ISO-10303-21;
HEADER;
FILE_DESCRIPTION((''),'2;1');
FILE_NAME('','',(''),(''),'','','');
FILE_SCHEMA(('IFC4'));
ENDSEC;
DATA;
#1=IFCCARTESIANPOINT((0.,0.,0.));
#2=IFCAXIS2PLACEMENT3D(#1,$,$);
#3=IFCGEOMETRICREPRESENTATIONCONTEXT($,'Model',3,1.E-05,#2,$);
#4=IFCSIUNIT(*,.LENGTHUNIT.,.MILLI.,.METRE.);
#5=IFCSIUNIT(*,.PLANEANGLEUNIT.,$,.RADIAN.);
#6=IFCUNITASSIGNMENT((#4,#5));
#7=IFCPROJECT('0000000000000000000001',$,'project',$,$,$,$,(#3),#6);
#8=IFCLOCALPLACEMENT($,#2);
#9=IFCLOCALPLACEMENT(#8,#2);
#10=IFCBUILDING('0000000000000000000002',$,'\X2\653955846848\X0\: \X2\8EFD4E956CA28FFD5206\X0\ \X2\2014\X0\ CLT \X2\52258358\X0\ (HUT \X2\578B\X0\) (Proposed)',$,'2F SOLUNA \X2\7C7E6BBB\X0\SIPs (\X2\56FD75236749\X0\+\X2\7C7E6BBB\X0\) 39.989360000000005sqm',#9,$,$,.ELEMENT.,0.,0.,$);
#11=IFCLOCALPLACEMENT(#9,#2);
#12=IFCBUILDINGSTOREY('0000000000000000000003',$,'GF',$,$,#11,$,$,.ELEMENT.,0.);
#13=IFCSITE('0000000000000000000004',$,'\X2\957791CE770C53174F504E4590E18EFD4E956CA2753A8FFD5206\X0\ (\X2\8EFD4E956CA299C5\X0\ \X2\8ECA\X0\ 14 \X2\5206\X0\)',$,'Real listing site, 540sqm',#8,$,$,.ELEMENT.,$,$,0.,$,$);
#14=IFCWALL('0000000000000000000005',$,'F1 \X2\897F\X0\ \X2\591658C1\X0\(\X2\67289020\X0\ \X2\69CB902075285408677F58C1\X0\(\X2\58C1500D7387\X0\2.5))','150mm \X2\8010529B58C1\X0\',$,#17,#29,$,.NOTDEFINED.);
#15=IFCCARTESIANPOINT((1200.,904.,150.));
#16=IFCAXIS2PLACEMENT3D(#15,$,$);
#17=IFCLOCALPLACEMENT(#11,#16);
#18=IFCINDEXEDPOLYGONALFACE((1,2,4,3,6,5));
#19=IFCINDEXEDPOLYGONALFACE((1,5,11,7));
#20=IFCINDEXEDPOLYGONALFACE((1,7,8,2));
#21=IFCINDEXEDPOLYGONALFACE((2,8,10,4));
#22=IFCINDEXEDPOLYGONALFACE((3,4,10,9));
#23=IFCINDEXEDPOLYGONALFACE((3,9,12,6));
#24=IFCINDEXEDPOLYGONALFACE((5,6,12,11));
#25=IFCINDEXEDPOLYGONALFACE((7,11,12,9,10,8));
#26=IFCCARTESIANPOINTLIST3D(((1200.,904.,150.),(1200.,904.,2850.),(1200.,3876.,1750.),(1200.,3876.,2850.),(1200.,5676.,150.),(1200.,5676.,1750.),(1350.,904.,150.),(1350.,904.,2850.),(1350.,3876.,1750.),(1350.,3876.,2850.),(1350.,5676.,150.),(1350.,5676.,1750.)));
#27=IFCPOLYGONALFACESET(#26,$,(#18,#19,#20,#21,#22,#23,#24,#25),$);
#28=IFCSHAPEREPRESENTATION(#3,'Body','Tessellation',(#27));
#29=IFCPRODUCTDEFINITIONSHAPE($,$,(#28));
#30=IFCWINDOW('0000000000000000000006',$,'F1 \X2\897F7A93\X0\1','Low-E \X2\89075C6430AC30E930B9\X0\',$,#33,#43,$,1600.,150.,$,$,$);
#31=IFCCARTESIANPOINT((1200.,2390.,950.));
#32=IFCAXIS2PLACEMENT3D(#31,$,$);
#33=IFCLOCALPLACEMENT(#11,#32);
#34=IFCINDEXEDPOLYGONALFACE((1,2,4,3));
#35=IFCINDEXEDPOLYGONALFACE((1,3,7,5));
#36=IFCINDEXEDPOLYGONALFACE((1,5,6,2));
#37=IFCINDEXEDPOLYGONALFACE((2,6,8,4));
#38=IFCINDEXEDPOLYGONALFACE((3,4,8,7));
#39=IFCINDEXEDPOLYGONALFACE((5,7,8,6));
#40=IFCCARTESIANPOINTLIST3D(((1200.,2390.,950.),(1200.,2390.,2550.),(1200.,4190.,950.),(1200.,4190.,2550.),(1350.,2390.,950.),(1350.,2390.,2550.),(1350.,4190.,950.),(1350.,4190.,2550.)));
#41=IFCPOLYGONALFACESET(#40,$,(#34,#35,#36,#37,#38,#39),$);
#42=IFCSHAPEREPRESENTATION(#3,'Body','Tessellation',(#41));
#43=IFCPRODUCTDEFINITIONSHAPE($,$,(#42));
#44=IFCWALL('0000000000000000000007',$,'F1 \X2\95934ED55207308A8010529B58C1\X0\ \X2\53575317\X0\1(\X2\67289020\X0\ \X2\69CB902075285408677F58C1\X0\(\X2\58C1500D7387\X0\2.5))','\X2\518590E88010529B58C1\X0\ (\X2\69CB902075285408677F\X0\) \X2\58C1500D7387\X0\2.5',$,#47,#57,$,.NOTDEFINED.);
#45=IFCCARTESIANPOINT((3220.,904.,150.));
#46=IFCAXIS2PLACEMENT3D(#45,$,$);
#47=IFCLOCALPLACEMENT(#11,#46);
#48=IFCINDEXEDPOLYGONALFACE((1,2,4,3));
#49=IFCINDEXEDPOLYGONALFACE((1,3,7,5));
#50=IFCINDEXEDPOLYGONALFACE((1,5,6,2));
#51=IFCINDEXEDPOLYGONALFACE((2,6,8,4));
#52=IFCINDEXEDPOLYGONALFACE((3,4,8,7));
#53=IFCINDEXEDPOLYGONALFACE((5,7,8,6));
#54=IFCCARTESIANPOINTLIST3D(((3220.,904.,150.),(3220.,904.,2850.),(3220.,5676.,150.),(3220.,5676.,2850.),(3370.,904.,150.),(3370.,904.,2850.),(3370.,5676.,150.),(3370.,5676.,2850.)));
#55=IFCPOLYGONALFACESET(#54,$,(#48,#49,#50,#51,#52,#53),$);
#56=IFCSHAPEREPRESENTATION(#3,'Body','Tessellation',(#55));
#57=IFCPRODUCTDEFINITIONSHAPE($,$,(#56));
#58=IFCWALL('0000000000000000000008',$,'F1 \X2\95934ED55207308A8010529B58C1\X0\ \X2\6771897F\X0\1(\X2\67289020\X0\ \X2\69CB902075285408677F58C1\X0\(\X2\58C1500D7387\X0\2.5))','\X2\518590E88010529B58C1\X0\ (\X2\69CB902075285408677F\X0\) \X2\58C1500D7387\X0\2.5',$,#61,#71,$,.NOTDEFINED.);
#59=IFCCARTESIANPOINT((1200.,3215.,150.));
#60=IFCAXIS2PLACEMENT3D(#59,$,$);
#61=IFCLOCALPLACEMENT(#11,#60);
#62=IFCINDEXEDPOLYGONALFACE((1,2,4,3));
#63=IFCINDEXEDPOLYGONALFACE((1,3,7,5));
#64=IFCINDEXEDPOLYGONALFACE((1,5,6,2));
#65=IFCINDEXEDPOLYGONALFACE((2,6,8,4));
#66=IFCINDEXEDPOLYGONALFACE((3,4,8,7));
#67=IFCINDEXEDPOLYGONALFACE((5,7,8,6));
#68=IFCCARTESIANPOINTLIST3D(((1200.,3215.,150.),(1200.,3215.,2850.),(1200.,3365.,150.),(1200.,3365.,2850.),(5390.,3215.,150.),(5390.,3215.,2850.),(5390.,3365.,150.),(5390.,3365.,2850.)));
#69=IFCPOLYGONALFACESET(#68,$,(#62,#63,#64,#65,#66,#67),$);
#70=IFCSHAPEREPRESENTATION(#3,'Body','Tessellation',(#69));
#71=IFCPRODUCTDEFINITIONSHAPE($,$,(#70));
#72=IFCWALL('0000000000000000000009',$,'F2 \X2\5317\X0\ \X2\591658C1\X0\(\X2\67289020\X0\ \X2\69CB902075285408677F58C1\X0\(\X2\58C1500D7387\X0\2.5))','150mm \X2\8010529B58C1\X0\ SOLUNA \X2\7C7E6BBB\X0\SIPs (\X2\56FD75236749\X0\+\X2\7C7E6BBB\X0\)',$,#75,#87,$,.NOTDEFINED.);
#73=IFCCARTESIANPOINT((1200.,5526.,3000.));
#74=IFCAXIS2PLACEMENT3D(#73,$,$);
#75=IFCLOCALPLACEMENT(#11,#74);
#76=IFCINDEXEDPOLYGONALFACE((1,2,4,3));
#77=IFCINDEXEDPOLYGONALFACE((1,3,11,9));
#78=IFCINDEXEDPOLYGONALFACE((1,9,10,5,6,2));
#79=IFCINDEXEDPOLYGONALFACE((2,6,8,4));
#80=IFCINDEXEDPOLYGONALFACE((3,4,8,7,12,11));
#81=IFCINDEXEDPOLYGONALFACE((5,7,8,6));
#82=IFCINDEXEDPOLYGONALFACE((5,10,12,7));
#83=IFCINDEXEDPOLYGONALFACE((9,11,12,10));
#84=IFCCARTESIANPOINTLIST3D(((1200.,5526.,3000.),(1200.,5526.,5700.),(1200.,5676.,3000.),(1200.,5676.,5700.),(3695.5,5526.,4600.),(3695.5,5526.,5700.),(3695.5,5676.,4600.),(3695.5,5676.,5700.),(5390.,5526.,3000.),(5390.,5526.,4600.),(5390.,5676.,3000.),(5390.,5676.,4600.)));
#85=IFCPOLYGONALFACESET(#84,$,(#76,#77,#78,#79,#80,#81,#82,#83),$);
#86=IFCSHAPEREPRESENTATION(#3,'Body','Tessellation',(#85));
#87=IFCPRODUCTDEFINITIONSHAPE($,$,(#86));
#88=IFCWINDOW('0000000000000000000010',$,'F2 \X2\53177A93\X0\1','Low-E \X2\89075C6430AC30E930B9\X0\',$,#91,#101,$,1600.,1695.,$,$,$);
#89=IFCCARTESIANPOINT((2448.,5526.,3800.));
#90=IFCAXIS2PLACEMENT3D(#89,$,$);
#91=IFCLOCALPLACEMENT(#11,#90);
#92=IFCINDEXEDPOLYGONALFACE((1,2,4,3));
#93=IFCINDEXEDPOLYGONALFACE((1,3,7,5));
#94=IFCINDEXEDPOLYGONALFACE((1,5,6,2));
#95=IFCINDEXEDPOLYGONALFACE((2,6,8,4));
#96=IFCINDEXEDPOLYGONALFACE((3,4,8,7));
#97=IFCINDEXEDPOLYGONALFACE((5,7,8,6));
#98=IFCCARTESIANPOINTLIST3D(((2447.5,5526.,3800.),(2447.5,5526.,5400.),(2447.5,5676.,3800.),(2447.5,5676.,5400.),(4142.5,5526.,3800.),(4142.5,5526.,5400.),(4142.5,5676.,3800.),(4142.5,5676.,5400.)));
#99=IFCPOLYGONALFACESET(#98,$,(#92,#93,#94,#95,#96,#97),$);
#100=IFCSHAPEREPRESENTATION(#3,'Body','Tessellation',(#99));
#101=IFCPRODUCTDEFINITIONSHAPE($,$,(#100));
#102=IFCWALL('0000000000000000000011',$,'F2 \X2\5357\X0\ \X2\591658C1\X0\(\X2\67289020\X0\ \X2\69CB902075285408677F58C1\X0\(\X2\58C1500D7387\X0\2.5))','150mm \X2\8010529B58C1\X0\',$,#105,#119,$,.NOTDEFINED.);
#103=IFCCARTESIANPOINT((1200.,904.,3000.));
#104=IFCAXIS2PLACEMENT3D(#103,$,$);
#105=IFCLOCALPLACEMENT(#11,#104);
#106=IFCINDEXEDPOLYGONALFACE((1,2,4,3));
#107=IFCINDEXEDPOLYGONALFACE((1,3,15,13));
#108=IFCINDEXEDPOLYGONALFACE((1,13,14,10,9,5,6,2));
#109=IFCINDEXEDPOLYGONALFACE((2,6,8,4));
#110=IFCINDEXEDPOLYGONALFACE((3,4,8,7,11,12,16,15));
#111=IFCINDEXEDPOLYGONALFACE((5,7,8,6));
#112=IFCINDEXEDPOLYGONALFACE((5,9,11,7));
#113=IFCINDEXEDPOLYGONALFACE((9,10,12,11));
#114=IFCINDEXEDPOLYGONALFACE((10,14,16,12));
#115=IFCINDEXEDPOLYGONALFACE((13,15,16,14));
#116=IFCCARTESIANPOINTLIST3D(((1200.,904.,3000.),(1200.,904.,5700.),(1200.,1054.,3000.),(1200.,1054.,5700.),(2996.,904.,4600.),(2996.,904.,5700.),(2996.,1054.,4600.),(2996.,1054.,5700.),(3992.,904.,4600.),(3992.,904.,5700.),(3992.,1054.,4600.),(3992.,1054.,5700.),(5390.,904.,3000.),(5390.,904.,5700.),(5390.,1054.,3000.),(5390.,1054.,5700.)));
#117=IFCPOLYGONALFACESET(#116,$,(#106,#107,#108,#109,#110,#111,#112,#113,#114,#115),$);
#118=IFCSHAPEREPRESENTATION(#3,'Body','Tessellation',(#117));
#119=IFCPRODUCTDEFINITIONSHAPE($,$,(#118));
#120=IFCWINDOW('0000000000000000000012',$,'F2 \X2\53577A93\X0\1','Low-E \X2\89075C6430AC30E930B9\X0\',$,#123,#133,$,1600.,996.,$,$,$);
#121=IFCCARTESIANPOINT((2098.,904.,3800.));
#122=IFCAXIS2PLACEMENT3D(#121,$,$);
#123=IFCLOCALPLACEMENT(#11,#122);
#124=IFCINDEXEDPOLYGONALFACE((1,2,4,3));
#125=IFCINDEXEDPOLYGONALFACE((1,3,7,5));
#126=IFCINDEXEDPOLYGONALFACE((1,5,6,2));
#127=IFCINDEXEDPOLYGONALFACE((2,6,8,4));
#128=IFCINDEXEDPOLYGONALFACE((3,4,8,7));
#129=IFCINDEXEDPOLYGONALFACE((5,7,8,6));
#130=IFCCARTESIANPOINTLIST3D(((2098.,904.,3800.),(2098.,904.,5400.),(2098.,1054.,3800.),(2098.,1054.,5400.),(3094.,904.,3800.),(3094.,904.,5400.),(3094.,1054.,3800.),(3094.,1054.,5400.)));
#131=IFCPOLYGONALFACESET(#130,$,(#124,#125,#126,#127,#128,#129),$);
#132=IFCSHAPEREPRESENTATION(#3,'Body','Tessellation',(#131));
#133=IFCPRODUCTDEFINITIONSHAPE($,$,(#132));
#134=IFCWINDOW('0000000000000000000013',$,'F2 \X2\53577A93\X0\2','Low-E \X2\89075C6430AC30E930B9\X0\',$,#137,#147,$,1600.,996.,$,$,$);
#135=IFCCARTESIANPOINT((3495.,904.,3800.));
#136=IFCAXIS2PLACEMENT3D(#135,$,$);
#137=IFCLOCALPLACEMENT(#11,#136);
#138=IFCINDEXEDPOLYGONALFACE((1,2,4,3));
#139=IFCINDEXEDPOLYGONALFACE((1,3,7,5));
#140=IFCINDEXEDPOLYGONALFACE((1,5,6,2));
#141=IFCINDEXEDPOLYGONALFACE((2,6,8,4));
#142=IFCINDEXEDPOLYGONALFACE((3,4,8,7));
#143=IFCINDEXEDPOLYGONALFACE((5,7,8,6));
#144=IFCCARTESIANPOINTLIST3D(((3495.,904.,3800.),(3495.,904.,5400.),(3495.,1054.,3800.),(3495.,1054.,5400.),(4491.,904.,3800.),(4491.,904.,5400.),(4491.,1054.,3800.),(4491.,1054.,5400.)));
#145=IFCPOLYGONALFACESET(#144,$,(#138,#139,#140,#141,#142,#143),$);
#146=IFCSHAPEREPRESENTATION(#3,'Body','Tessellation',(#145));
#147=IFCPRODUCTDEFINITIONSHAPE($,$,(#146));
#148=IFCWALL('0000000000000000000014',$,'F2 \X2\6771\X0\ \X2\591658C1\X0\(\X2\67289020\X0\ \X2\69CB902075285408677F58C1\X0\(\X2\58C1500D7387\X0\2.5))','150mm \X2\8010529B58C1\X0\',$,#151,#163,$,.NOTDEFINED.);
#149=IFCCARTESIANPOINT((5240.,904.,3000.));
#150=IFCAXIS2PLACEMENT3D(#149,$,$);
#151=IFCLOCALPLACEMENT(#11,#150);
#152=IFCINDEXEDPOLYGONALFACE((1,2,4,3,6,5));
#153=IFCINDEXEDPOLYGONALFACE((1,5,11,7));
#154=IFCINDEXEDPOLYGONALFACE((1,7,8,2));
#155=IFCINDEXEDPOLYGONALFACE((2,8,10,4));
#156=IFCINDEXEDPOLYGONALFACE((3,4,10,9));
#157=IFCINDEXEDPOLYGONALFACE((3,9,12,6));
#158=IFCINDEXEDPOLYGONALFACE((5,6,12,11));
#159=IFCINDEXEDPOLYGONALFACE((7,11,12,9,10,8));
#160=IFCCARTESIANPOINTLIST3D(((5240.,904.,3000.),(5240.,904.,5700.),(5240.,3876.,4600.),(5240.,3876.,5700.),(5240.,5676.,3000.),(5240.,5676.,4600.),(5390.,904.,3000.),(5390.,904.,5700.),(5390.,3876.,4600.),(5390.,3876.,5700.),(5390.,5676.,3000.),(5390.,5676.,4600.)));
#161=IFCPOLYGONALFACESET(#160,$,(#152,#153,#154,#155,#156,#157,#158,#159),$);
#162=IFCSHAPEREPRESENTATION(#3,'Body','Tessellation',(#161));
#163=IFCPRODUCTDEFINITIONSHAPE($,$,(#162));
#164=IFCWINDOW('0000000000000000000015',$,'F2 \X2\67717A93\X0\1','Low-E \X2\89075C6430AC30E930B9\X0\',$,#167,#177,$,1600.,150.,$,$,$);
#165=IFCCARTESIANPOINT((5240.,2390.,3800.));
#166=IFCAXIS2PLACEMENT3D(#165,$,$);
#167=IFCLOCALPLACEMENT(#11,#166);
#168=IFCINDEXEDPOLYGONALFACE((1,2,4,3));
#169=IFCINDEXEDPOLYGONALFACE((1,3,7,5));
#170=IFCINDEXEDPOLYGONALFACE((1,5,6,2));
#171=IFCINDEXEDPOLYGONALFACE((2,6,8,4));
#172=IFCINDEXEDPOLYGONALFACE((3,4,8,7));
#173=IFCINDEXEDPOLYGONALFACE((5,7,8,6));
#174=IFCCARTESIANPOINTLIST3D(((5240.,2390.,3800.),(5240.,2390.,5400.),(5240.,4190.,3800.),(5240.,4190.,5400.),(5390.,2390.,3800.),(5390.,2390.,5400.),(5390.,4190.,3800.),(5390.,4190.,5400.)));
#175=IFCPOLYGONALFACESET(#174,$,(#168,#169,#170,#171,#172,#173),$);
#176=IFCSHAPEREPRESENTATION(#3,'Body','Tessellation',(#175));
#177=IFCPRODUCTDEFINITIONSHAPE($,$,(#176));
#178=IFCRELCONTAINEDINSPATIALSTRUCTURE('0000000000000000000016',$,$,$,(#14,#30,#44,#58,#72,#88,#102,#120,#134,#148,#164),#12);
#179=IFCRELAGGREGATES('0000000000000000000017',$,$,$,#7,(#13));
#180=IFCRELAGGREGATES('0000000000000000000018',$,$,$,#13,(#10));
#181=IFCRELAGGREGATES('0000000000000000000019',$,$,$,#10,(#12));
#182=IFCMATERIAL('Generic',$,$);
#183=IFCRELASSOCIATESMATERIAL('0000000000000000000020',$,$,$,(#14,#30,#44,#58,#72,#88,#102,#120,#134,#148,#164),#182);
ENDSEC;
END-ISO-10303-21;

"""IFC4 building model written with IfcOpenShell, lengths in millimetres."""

from ifc_helpers import new_model, si_unit, frame, frame_2d, origin, place, context, project, spatial, rectangle, extrude, material, element, fill, save


model = new_model("IFC4")

# Units and contexts
model_context = context("Model", 3, precision=1e-05, world=origin())
ifc_project = project(units=[si_unit("LENGTHUNIT", "METRE", prefix="MILLI"), si_unit("PLANEANGLEUNIT", "RADIAN")], contexts=[model_context])

# Site, building, storey
site_placement = place(None, origin())
site = spatial("IfcSite", under=ifc_project, at=site_placement, Name="長野県北佐久郡軽井沢町追分 (軽井沢駅 車 14 分)", ObjectType="Real listing site, 540sqm", CompositionType="ELEMENT", RefElevation=0.0)
building_placement = place(site_placement, origin())
building = spatial("IfcBuilding", under=site, at=building_placement, Name="改善案: 軽井沢追分 — CLT 別荘 (HUT 型) (Proposed)", ObjectType="2F SOLUNA 籾殻SIPs (国産杉+籾殻) 39.989360000000005sqm", CompositionType="ELEMENT", ElevationOfRefHeight=0.0, ElevationOfTerrain=0.0)
storey_placement = place(building_placement, origin())
storey = spatial("IfcBuildingStorey", under=building, at=storey_placement, Name="GF", CompositionType="ELEMENT", Elevation=0.0)

# Shared definitions
ifc_material_1 = material(Name="Generic")

# Wall, opening, window
wall_1_placement = place(storey_placement, frame((1200.0, 904.0, 150.0)))
wall_1 = element("IfcWall", 1, at=wall_1_placement, inside=storey, material=ifc_material_1, Name="F1 西 外壁(木造 構造用合板壁(壁倍率2.5))", Description="150mm 耐力壁", PredefinedType="NOTDEFINED", context=model_context, shape_type="SweptSolid", body=[
    extrude(rectangle(XDim=150.0, YDim=4772.0, at=frame_2d((75.0, 2386.0))), frame((1200.0, 904.0, 150.0)), (0.0, 0.0, 1.0), 2700.0),
])
opening_1_placement = place(storey_placement, frame((1200.0, 2390.0, 950.0)))
opening_1 = element("IfcOpeningElement", 2, at=opening_1_placement, cuts=wall_1, PredefinedType="NOTDEFINED", context=model_context, shape_type="SweptSolid", body=[
    extrude(rectangle(XDim=150.0, YDim=1800.0, at=frame_2d((75.0, 900.0))), frame((1200.0, 2390.0, 950.0)), (0.0, 0.0, 1.0), 1600.0),
])
window_1_placement = place(storey_placement, frame((1200.0, 2390.0, 950.0)))
window_1 = element("IfcWindow", 3, at=window_1_placement, inside=storey, material=ifc_material_1, Name="F1 西窓1", Description="Low-E 複層ガラス", OverallHeight=1600.0, OverallWidth=150.0, context=model_context, shape_type="SweptSolid", body=[
    extrude(rectangle(XDim=150.0, YDim=1800.0, at=frame_2d((75.0, 900.0))), frame((1200.0, 2390.0, 950.0)), (0.0, 0.0, 1.0), 1600.0),
])
fill(opening_1, window_1)

# Walls
wall_2_placement = place(storey_placement, frame((3220.0, 904.0, 150.0)))
element("IfcWall", 4, at=wall_2_placement, inside=storey, material=ifc_material_1, Name="F1 間仕切り耐力壁 南北1(木造 構造用合板壁(壁倍率2.5))", Description="内部耐力壁 (構造用合板) 壁倍率2.5", PredefinedType="NOTDEFINED", context=model_context, shape_type="SweptSolid", body=[
    extrude(rectangle(XDim=150.0, YDim=4772.0, at=frame_2d((75.0, 2386.0))), frame((3220.0, 904.0, 150.0)), (0.0, 0.0, 1.0), 2700.0),
])
wall_3_placement = place(storey_placement, frame((1200.0, 3215.0, 150.0)))
element("IfcWall", 5, at=wall_3_placement, inside=storey, material=ifc_material_1, Name="F1 間仕切り耐力壁 東西1(木造 構造用合板壁(壁倍率2.5))", Description="内部耐力壁 (構造用合板) 壁倍率2.5", PredefinedType="NOTDEFINED", context=model_context, shape_type="SweptSolid", body=[
    extrude(rectangle(XDim=4190.0, YDim=150.0, at=frame_2d((2095.0, 75.0))), frame((1200.0, 3215.0, 150.0)), (0.0, 0.0, 1.0), 2700.0),
])

# Wall, opening, window
wall_4_placement = place(storey_placement, frame((1200.0, 5526.0, 3000.0)))
wall_4 = element("IfcWall", 6, at=wall_4_placement, inside=storey, material=ifc_material_1, Name="F2 北 外壁(木造 構造用合板壁(壁倍率2.5))", Description="150mm 耐力壁 SOLUNA 籾殻SIPs (国産杉+籾殻)", PredefinedType="NOTDEFINED", context=model_context, shape_type="SweptSolid", body=[
    extrude(rectangle(XDim=4190.0, YDim=150.0, at=frame_2d((2095.0, 75.0))), frame((1200.0, 5526.0, 3000.0)), (0.0, 0.0, 1.0), 2700.0),
])
opening_2_placement = place(storey_placement, frame((2448.0, 5526.0, 3800.0)))
opening_2 = element("IfcOpeningElement", 7, at=opening_2_placement, cuts=wall_4, PredefinedType="NOTDEFINED", context=model_context, shape_type="SweptSolid", body=[
    extrude(rectangle(XDim=1695.0, YDim=150.0, at=frame_2d((847.0, 75.0))), frame((2448.0, 5526.0, 3800.0)), (0.0, 0.0, 1.0), 1600.0),
])
window_2_placement = place(storey_placement, frame((2448.0, 5526.0, 3800.0)))
window_2 = element("IfcWindow", 8, at=window_2_placement, inside=storey, material=ifc_material_1, Name="F2 北窓1", Description="Low-E 複層ガラス", OverallHeight=1600.0, OverallWidth=1695.0, context=model_context, shape_type="SweptSolid", body=[
    extrude(rectangle(XDim=1695.0, YDim=150.0, at=frame_2d((847.0, 75.0))), frame((2448.0, 5526.0, 3800.0)), (0.0, 0.0, 1.0), 1600.0),
])
fill(opening_2, window_2)

# Wall, openings, windows
wall_5_placement = place(storey_placement, frame((1200.0, 904.0, 3000.0)))
wall_5 = element("IfcWall", 9, at=wall_5_placement, inside=storey, material=ifc_material_1, Name="F2 南 外壁(木造 構造用合板壁(壁倍率2.5))", Description="150mm 耐力壁", PredefinedType="NOTDEFINED", context=model_context, shape_type="SweptSolid", body=[
    extrude(rectangle(XDim=4190.0, YDim=150.0, at=frame_2d((2095.0, 75.0))), frame((1200.0, 904.0, 3000.0)), (0.0, 0.0, 1.0), 2700.0),
])
opening_3_placement = place(storey_placement, frame((2098.0, 904.0, 3800.0)))
opening_3 = element("IfcOpeningElement", 10, at=opening_3_placement, cuts=wall_5, PredefinedType="NOTDEFINED", context=model_context, shape_type="SweptSolid", body=[
    extrude(rectangle(XDim=996.0, YDim=150.0, at=frame_2d((498.0, 75.0))), frame((2098.0, 904.0, 3800.0)), (0.0, 0.0, 1.0), 1600.0),
])
opening_4_placement = place(storey_placement, frame((3495.0, 904.0, 3800.0)))
opening_4 = element("IfcOpeningElement", 11, at=opening_4_placement, cuts=wall_5, PredefinedType="NOTDEFINED", context=model_context, shape_type="SweptSolid", body=[
    extrude(rectangle(XDim=996.0, YDim=150.0, at=frame_2d((498.0, 75.0))), frame((3495.0, 904.0, 3800.0)), (0.0, 0.0, 1.0), 1600.0),
])
window_3_placement = place(storey_placement, frame((2098.0, 904.0, 3800.0)))
window_3 = element("IfcWindow", 12, at=window_3_placement, inside=storey, material=ifc_material_1, Name="F2 南窓1", Description="Low-E 複層ガラス", OverallHeight=1600.0, OverallWidth=996.0, context=model_context, shape_type="SweptSolid", body=[
    extrude(rectangle(XDim=996.0, YDim=150.0, at=frame_2d((498.0, 75.0))), frame((2098.0, 904.0, 3800.0)), (0.0, 0.0, 1.0), 1600.0),
])
fill(opening_3, window_3)
window_4_placement = place(storey_placement, frame((3495.0, 904.0, 3800.0)))
window_4 = element("IfcWindow", 13, at=window_4_placement, inside=storey, material=ifc_material_1, Name="F2 南窓2", Description="Low-E 複層ガラス", OverallHeight=1600.0, OverallWidth=996.0, context=model_context, shape_type="SweptSolid", body=[
    extrude(rectangle(XDim=996.0, YDim=150.0, at=frame_2d((498.0, 75.0))), frame((3495.0, 904.0, 3800.0)), (0.0, 0.0, 1.0), 1600.0),
])
fill(opening_4, window_4)

# Wall, opening, window
wall_6_placement = place(storey_placement, frame((5240.0, 904.0, 3000.0)))
wall_6 = element("IfcWall", 14, at=wall_6_placement, inside=storey, material=ifc_material_1, Name="F2 東 外壁(木造 構造用合板壁(壁倍率2.5))", Description="150mm 耐力壁", PredefinedType="NOTDEFINED", context=model_context, shape_type="SweptSolid", body=[
    extrude(rectangle(XDim=150.0, YDim=4772.0, at=frame_2d((75.0, 2386.0))), frame((5240.0, 904.0, 3000.0)), (0.0, 0.0, 1.0), 2700.0),
])
opening_5_placement = place(storey_placement, frame((5240.0, 2390.0, 3800.0)))
opening_5 = element("IfcOpeningElement", 15, at=opening_5_placement, cuts=wall_6, PredefinedType="NOTDEFINED", context=model_context, shape_type="SweptSolid", body=[
    extrude(rectangle(XDim=150.0, YDim=1800.0, at=frame_2d((75.0, 900.0))), frame((5240.0, 2390.0, 3800.0)), (0.0, 0.0, 1.0), 1600.0),
])
window_5_placement = place(storey_placement, frame((5240.0, 2390.0, 3800.0)))
window_5 = element("IfcWindow", 16, at=window_5_placement, inside=storey, material=ifc_material_1, Name="F2 東窓1", Description="Low-E 複層ガラス", OverallHeight=1600.0, OverallWidth=150.0, context=model_context, shape_type="SweptSolid", body=[
    extrude(rectangle(XDim=150.0, YDim=1800.0, at=frame_2d((75.0, 900.0))), frame((5240.0, 2390.0, 3800.0)), (0.0, 0.0, 1.0), 1600.0),
])
fill(opening_5, window_5)

save(model, "model.ifc")
